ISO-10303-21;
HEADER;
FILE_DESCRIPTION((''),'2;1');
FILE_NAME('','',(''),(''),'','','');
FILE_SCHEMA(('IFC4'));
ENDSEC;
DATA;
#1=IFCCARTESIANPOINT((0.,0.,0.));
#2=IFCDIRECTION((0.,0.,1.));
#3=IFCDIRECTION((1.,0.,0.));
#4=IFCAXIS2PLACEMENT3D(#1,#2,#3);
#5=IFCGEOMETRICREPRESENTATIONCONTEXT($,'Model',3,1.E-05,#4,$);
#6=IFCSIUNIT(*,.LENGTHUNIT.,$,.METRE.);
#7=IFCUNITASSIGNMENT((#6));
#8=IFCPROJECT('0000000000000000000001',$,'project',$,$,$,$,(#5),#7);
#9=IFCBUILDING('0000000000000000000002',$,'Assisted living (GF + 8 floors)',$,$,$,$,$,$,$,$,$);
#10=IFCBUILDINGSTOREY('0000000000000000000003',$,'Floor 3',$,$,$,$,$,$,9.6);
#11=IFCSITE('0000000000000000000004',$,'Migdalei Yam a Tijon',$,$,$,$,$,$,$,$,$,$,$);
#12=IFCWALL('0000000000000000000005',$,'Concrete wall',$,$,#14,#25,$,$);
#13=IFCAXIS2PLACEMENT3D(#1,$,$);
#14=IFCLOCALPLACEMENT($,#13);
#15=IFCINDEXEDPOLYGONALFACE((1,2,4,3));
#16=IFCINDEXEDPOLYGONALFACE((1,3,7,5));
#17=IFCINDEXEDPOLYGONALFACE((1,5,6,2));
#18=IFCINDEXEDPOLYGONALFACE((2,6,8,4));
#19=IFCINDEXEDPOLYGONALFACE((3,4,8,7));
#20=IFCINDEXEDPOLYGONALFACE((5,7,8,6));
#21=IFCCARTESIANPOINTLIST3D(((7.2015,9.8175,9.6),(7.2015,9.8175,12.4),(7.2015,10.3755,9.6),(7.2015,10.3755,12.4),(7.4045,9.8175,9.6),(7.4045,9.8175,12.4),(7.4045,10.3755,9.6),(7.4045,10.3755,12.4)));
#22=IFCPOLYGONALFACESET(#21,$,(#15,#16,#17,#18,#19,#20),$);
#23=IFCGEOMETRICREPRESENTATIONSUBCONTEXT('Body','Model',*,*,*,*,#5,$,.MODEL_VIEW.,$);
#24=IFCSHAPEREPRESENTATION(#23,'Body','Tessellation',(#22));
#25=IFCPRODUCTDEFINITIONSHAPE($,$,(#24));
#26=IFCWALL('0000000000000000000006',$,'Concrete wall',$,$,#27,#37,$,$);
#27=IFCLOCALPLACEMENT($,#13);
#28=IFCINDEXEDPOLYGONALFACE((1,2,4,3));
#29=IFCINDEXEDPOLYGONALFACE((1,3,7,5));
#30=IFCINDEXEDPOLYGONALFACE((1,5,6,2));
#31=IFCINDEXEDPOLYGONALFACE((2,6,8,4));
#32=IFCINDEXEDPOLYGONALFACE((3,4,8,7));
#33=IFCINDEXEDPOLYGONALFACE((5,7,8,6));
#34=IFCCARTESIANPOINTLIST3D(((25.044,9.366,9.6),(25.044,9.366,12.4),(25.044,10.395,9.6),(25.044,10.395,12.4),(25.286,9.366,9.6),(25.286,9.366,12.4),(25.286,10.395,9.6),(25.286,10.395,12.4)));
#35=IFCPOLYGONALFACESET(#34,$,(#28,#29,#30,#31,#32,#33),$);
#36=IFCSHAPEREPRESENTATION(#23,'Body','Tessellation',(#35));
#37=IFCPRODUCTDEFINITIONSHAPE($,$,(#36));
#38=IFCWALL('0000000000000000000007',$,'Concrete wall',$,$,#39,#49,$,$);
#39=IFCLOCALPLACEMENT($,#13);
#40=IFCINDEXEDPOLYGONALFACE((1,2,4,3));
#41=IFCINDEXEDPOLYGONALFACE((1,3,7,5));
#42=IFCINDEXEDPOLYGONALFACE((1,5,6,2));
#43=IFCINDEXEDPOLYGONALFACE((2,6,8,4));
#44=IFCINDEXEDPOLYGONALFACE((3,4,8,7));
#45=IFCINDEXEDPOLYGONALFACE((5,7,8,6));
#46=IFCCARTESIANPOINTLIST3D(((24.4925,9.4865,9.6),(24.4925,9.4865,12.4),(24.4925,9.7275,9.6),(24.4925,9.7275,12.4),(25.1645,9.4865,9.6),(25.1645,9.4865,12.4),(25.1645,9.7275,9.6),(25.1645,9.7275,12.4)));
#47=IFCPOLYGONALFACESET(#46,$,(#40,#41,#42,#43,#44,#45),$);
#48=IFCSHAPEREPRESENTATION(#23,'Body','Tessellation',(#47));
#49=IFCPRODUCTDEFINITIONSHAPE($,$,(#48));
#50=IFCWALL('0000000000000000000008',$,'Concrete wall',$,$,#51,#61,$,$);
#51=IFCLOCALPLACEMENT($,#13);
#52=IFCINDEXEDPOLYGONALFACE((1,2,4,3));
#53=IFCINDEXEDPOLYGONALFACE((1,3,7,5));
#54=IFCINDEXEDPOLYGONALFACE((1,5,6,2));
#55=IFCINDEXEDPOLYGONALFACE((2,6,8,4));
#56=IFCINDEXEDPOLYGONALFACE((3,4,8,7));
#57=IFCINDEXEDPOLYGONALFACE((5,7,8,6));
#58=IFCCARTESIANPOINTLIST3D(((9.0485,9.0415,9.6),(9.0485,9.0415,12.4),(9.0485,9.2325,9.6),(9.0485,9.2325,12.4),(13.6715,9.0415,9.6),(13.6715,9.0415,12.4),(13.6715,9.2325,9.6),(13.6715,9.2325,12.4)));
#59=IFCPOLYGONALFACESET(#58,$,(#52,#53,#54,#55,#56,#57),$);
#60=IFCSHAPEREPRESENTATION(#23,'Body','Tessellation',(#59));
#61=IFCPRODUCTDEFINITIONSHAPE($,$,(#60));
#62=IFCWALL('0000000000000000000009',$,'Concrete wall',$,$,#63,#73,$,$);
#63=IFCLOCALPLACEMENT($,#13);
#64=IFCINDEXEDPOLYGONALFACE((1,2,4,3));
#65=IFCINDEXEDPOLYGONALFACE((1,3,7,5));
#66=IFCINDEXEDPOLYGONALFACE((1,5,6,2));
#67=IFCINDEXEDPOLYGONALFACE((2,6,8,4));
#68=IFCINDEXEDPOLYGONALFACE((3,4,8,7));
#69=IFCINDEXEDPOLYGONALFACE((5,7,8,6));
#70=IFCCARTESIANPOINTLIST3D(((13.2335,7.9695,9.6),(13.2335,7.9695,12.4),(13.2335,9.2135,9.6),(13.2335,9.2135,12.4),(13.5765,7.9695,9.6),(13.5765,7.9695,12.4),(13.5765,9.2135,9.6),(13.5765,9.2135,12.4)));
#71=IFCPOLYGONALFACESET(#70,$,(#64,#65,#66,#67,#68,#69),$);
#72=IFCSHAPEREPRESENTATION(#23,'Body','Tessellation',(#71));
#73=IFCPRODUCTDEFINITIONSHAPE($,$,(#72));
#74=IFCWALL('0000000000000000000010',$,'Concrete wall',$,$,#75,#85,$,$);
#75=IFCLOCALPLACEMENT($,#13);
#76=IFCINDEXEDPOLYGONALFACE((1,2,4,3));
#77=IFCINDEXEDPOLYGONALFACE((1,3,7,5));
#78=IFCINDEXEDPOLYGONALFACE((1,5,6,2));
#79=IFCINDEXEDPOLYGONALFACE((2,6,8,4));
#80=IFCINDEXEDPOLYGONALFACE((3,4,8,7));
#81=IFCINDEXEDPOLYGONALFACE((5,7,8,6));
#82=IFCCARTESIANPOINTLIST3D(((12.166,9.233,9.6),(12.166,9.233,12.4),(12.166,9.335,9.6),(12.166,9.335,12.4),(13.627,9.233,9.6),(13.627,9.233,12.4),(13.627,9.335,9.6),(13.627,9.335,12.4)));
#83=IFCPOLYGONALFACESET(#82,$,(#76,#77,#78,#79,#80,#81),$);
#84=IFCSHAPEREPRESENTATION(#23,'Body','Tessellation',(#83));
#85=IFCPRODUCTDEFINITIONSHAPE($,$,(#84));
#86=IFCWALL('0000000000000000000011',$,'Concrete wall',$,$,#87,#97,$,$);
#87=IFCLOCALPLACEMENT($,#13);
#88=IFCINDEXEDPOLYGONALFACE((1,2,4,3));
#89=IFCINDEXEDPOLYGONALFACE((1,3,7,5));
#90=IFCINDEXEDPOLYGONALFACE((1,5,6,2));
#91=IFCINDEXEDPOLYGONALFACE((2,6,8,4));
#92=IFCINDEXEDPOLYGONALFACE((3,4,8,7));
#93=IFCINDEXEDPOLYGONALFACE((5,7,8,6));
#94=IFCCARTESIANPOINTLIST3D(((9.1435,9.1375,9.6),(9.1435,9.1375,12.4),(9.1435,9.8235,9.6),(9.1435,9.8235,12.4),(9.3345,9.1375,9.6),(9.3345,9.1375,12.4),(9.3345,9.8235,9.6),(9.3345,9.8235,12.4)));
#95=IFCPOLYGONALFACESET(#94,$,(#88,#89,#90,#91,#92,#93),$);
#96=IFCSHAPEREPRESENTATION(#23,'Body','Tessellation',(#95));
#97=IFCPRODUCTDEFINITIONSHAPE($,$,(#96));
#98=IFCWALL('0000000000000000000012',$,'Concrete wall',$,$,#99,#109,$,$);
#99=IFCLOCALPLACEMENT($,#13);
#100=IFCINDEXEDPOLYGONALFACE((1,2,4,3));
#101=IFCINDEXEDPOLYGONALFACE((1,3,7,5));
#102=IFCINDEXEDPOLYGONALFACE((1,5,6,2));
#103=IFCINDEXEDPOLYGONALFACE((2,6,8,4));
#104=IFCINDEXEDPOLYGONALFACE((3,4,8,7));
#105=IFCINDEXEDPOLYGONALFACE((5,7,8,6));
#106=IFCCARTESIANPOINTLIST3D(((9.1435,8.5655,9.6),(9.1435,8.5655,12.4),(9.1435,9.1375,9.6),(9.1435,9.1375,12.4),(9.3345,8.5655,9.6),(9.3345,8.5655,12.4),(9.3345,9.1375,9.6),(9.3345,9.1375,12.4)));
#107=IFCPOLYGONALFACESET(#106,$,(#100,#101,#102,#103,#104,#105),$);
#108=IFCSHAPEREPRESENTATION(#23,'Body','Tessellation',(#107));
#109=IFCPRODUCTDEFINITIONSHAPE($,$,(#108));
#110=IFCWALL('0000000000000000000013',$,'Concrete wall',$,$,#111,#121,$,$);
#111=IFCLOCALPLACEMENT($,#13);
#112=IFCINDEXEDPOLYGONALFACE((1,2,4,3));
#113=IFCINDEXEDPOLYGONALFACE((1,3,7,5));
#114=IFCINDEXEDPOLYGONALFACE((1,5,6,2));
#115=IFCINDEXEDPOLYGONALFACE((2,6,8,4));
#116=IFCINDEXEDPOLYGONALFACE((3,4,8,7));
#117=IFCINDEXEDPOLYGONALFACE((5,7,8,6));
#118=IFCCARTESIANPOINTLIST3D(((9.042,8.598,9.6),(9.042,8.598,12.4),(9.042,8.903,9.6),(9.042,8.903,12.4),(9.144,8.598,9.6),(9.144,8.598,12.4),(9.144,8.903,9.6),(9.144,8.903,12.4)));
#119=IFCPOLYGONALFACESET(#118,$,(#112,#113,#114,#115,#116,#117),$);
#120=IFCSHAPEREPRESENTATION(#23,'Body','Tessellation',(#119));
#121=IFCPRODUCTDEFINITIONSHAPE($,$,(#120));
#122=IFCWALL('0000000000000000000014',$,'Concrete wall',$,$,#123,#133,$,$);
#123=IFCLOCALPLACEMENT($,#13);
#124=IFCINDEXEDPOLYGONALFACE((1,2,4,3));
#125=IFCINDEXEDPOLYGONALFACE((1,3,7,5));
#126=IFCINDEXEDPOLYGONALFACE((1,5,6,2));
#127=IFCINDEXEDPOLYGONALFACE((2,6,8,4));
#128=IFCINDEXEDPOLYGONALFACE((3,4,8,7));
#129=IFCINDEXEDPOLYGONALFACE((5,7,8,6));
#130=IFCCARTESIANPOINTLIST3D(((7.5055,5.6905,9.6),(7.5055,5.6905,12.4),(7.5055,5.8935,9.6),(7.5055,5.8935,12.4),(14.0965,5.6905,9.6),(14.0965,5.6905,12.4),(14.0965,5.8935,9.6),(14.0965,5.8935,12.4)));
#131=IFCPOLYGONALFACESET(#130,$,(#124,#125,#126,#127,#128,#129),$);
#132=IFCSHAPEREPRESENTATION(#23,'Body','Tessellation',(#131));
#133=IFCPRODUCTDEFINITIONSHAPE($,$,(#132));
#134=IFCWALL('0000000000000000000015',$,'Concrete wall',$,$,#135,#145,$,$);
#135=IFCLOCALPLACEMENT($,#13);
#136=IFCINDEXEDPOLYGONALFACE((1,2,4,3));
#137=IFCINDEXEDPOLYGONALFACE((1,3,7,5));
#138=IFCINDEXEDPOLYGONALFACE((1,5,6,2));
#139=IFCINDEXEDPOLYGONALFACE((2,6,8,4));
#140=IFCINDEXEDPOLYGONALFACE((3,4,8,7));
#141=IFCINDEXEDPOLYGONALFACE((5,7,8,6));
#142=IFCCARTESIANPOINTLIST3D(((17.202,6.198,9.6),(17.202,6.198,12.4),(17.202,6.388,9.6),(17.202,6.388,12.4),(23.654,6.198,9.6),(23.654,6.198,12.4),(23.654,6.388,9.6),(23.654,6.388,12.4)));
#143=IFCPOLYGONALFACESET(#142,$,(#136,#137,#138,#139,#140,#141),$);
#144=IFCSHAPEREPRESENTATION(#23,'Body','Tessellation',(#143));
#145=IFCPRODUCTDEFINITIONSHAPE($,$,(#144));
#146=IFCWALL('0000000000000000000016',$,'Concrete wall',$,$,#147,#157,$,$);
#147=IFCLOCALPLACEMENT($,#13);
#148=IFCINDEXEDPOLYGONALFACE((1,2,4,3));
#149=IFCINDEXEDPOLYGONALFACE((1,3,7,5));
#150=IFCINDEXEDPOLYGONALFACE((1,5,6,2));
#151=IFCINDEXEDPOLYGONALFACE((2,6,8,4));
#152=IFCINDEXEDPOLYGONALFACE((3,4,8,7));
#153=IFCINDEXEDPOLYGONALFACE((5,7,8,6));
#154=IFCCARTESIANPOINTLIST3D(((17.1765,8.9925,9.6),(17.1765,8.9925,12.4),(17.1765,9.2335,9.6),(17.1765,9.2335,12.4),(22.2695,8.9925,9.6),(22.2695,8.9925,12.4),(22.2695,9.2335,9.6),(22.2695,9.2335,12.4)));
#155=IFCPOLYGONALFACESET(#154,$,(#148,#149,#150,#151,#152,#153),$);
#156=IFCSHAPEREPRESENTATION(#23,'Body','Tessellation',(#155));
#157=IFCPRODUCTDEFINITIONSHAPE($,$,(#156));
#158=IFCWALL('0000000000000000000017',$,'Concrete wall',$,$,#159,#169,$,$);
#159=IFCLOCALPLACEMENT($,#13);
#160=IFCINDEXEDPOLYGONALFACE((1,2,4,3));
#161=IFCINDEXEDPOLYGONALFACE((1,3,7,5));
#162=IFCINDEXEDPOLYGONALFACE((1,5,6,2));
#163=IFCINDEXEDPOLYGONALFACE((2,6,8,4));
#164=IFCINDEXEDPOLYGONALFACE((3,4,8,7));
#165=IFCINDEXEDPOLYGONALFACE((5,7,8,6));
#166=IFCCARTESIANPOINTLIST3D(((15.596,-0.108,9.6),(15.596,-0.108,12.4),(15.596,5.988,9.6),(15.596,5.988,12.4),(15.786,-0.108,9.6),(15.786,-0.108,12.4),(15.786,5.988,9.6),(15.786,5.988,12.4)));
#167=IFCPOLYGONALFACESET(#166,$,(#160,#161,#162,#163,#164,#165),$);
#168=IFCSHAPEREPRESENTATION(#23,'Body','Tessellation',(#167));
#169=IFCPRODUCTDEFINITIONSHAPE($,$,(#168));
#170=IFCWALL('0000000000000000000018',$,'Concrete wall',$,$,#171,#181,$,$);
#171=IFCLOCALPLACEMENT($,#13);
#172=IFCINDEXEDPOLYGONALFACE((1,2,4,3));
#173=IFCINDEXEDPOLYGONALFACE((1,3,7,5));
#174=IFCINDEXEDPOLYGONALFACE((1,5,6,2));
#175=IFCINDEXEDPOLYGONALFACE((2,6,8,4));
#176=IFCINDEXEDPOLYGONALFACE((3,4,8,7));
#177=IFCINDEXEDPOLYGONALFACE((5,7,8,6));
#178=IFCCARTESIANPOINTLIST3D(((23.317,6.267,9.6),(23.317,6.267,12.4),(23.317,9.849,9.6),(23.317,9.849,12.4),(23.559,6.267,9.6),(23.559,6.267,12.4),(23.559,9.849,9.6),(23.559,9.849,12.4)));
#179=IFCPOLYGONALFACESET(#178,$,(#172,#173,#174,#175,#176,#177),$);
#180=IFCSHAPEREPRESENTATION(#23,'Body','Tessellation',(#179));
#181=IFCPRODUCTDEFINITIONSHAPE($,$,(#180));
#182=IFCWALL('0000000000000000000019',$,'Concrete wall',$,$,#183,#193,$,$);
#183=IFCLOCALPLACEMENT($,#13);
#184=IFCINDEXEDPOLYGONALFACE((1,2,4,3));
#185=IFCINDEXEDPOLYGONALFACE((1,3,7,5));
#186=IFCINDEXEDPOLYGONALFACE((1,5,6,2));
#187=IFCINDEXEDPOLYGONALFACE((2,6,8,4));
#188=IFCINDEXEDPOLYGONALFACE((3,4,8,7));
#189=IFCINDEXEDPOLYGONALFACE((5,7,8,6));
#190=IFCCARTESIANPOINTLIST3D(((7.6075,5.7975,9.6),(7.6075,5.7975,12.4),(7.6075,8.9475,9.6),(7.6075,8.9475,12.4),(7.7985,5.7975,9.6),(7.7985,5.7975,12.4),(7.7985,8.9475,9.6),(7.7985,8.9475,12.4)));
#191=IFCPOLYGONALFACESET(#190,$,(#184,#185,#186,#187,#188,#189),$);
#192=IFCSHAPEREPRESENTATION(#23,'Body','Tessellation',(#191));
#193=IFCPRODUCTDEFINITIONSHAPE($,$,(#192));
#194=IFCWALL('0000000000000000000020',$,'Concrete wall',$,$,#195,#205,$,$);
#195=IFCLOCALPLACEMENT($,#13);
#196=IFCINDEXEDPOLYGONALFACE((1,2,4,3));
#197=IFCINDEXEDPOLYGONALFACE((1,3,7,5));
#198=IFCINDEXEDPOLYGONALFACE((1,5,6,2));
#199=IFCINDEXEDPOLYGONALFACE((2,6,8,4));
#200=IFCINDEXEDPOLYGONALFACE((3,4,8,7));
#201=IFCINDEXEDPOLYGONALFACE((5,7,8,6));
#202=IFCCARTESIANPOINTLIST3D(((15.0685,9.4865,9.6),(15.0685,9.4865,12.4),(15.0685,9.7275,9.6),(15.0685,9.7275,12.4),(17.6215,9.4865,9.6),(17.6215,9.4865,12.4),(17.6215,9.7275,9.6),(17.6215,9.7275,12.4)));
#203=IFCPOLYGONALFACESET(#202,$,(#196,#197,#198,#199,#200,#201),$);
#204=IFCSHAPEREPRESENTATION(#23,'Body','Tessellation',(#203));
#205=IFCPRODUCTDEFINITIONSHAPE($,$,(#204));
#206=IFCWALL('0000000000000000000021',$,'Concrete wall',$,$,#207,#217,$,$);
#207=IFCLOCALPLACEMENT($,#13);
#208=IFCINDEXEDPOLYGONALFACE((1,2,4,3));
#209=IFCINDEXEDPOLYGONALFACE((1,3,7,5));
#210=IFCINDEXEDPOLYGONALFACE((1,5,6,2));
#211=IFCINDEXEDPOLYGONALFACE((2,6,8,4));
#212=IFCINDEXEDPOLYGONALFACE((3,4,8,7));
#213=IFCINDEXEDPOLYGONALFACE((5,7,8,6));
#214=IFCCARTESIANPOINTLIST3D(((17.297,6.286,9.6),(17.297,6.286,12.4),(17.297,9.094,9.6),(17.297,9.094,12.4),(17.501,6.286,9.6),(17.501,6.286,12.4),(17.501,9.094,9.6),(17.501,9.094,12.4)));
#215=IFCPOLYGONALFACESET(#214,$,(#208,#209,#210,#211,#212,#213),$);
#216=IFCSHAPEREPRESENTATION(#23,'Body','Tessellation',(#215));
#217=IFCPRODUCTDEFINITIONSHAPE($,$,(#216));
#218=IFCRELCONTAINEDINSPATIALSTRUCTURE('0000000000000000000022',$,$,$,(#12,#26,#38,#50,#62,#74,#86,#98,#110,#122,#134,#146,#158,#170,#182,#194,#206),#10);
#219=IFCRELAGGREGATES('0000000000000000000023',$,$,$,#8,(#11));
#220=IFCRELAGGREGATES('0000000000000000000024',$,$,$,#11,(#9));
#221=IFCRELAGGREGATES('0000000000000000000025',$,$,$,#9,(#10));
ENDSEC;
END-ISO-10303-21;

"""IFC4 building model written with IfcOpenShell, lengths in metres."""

from ifc_helpers import new_model, si_unit, frame, origin_with_axes, context, subcontext, project, spatial, line, indexed_curve, outline, extrude, element, save


model = new_model("IFC4")

# Units and contexts
model_context = context("Model", 3, precision=1e-05, world=origin_with_axes())
body_context = subcontext(model_context, "Body", "Model", "MODEL_VIEW")
ifc_project = project(units=[si_unit("LENGTHUNIT", "METRE")], contexts=[model_context])

# Site, building, storey
site = spatial("IfcSite", under=ifc_project, Name="Migdalei Yam a Tijon")
building = spatial("IfcBuilding", under=site, Name="Assisted living (GF + 8 floors)")
storey = spatial("IfcBuildingStorey", under=building, Name="Floor 3", Elevation=9.6)

# Walls
element("IfcWall", 1, inside=storey, Name="Concrete wall", context=body_context, shape_type="SweptSolid", body=[
    extrude(outline(indexed_curve([(0.0, 0.0), (0.203, 0.0), (0.203, 0.558), (0.0, 0.558)], segments=[line(1, 2, 3, 4, 1)])), frame((7.2015, 9.8175, 9.6), z_axis=(0.0, 0.0, 1.0), x_axis=(1.0, 0.0, 0.0)), (0.0, 0.0, 1.0), 2.8),
])
element("IfcWall", 2, inside=storey, Name="Concrete wall", context=body_context, shape_type="SweptSolid", body=[
    extrude(outline(indexed_curve([(0.0, 0.0), (0.242, 0.0), (0.242, 1.029), (0.0, 1.029)], segments=[line(1, 2, 3, 4, 1)])), frame((25.044, 9.366, 9.6), z_axis=(0.0, 0.0, 1.0), x_axis=(1.0, 0.0, 0.0)), (0.0, 0.0, 1.0), 2.8),
])
element("IfcWall", 3, inside=storey, Name="Concrete wall", context=body_context, shape_type="SweptSolid", body=[
    extrude(outline(indexed_curve([(0.0, 0.0), (0.672, 0.0), (0.672, 0.241), (0.0, 0.241)], segments=[line(1, 2, 3, 4, 1)])), frame((24.4925, 9.4865, 9.6), z_axis=(0.0, 0.0, 1.0), x_axis=(1.0, 0.0, 0.0)), (0.0, 0.0, 1.0), 2.8),
])
element("IfcWall", 4, inside=storey, Name="Concrete wall", context=body_context, shape_type="SweptSolid", body=[
    extrude(outline(indexed_curve([(0.0, 0.0), (4.623, 0.0), (4.623, 0.191), (0.0, 0.191)], segments=[line(1, 2, 3, 4, 1)])), frame((9.0485, 9.0415, 9.6), z_axis=(0.0, 0.0, 1.0), x_axis=(1.0, 0.0, 0.0)), (0.0, 0.0, 1.0), 2.8),
])
element("IfcWall", 5, inside=storey, Name="Concrete wall", context=body_context, shape_type="SweptSolid", body=[
    extrude(outline(indexed_curve([(0.0, 0.0), (0.343, 0.0), (0.343, 1.244), (0.0, 1.244)], segments=[line(1, 2, 3, 4, 1)])), frame((13.2335, 7.9695, 9.6), z_axis=(0.0, 0.0, 1.0), x_axis=(1.0, 0.0, 0.0)), (0.0, 0.0, 1.0), 2.8),
])
element("IfcWall", 6, inside=storey, Name="Concrete wall", context=body_context, shape_type="SweptSolid", body=[
    extrude(outline(indexed_curve([(0.0, 0.0), (1.461, 0.0), (1.461, 0.102), (0.0, 0.102)], segments=[line(1, 2, 3, 4, 1)])), frame((12.166, 9.233, 9.6), z_axis=(0.0, 0.0, 1.0), x_axis=(1.0, 0.0, 0.0)), (0.0, 0.0, 1.0), 2.8),
])
element("IfcWall", 7, inside=storey, Name="Concrete wall", context=body_context, shape_type="SweptSolid", body=[
    extrude(outline(indexed_curve([(0.0, 0.0), (0.191, 0.0), (0.191, 0.686), (0.0, 0.686)], segments=[line(1, 2, 3, 4, 1)])), frame((9.1435, 9.1375, 9.6), z_axis=(0.0, 0.0, 1.0), x_axis=(1.0, 0.0, 0.0)), (0.0, 0.0, 1.0), 2.8),
])
element("IfcWall", 8, inside=storey, Name="Concrete wall", context=body_context, shape_type="SweptSolid", body=[
    extrude(outline(indexed_curve([(0.0, 0.0), (0.191, 0.0), (0.191, 0.572), (0.0, 0.572)], segments=[line(1, 2, 3, 4, 1)])), frame((9.1435, 8.5655, 9.6), z_axis=(0.0, 0.0, 1.0), x_axis=(1.0, 0.0, 0.0)), (0.0, 0.0, 1.0), 2.8),
])
element("IfcWall", 9, inside=storey, Name="Concrete wall", context=body_context, shape_type="SweptSolid", body=[
    extrude(outline(indexed_curve([(0.0, 0.0), (0.102, 0.0), (0.102, 0.305), (0.0, 0.305)], segments=[line(1, 2, 3, 4, 1)])), frame((9.042, 8.598, 9.6), z_axis=(0.0, 0.0, 1.0), x_axis=(1.0, 0.0, 0.0)), (0.0, 0.0, 1.0), 2.8),
])
element("IfcWall", 10, inside=storey, Name="Concrete wall", context=body_context, shape_type="SweptSolid", body=[
    extrude(outline(indexed_curve([(0.0, 0.0), (6.591, 0.0), (6.591, 0.203), (0.0, 0.203)], segments=[line(1, 2, 3, 4, 1)])), frame((7.5055, 5.6905, 9.6), z_axis=(0.0, 0.0, 1.0), x_axis=(1.0, 0.0, 0.0)), (0.0, 0.0, 1.0), 2.8),
])
element("IfcWall", 11, inside=storey, Name="Concrete wall", context=body_context, shape_type="SweptSolid", body=[
    extrude(outline(indexed_curve([(0.0, 0.0), (6.452, 0.0), (6.452, 0.19), (0.0, 0.19)], segments=[line(1, 2, 3, 4, 1)])), frame((17.202, 6.198, 9.6), z_axis=(0.0, 0.0, 1.0), x_axis=(1.0, 0.0, 0.0)), (0.0, 0.0, 1.0), 2.8),
])
element("IfcWall", 12, inside=storey, Name="Concrete wall", context=body_context, shape_type="SweptSolid", body=[
    extrude(outline(indexed_curve([(0.0, 0.0), (5.093, 0.0), (5.093, 0.241), (0.0, 0.241)], segments=[line(1, 2, 3, 4, 1)])), frame((17.1765, 8.9925, 9.6), z_axis=(0.0, 0.0, 1.0), x_axis=(1.0, 0.0, 0.0)), (0.0, 0.0, 1.0), 2.8),
])
element("IfcWall", 13, inside=storey, Name="Concrete wall", context=body_context, shape_type="SweptSolid", body=[
    extrude(outline(indexed_curve([(0.0, 0.0), (0.19, 0.0), (0.19, 6.096), (0.0, 6.096)], segments=[line(1, 2, 3, 4, 1)])), frame((15.596, -0.108, 9.6), z_axis=(0.0, 0.0, 1.0), x_axis=(1.0, 0.0, 0.0)), (0.0, 0.0, 1.0), 2.8),
])
element("IfcWall", 14, inside=storey, Name="Concrete wall", context=body_context, shape_type="SweptSolid", body=[
    extrude(outline(indexed_curve([(0.0, 0.0), (0.242, 0.0), (0.242, 3.582), (0.0, 3.582)], segments=[line(1, 2, 3, 4, 1)])), frame((23.317, 6.267, 9.6), z_axis=(0.0, 0.0, 1.0), x_axis=(1.0, 0.0, 0.0)), (0.0, 0.0, 1.0), 2.8),
])
element("IfcWall", 15, inside=storey, Name="Concrete wall", context=body_context, shape_type="SweptSolid", body=[
    extrude(outline(indexed_curve([(0.0, 0.0), (0.191, 0.0), (0.191, 3.15), (0.0, 3.15)], segments=[line(1, 2, 3, 4, 1)])), frame((7.6075, 5.7975, 9.6), z_axis=(0.0, 0.0, 1.0), x_axis=(1.0, 0.0, 0.0)), (0.0, 0.0, 1.0), 2.8),
])
element("IfcWall", 16, inside=storey, Name="Concrete wall", context=body_context, shape_type="SweptSolid", body=[
    extrude(outline(indexed_curve([(0.0, 0.0), (2.553, 0.0), (2.553, 0.241), (0.0, 0.241)], segments=[line(1, 2, 3, 4, 1)])), frame((15.0685, 9.4865, 9.6), z_axis=(0.0, 0.0, 1.0), x_axis=(1.0, 0.0, 0.0)), (0.0, 0.0, 1.0), 2.8),
])
element("IfcWall", 17, inside=storey, Name="Concrete wall", context=body_context, shape_type="SweptSolid", body=[
    extrude(outline(indexed_curve([(0.0, 0.0), (0.204, 0.0), (0.204, 2.808), (0.0, 2.808)], segments=[line(1, 2, 3, 4, 1)])), frame((17.297, 6.286, 9.6), z_axis=(0.0, 0.0, 1.0), x_axis=(1.0, 0.0, 0.0)), (0.0, 0.0, 1.0), 2.8),
])

save(model, "model.ifc")
